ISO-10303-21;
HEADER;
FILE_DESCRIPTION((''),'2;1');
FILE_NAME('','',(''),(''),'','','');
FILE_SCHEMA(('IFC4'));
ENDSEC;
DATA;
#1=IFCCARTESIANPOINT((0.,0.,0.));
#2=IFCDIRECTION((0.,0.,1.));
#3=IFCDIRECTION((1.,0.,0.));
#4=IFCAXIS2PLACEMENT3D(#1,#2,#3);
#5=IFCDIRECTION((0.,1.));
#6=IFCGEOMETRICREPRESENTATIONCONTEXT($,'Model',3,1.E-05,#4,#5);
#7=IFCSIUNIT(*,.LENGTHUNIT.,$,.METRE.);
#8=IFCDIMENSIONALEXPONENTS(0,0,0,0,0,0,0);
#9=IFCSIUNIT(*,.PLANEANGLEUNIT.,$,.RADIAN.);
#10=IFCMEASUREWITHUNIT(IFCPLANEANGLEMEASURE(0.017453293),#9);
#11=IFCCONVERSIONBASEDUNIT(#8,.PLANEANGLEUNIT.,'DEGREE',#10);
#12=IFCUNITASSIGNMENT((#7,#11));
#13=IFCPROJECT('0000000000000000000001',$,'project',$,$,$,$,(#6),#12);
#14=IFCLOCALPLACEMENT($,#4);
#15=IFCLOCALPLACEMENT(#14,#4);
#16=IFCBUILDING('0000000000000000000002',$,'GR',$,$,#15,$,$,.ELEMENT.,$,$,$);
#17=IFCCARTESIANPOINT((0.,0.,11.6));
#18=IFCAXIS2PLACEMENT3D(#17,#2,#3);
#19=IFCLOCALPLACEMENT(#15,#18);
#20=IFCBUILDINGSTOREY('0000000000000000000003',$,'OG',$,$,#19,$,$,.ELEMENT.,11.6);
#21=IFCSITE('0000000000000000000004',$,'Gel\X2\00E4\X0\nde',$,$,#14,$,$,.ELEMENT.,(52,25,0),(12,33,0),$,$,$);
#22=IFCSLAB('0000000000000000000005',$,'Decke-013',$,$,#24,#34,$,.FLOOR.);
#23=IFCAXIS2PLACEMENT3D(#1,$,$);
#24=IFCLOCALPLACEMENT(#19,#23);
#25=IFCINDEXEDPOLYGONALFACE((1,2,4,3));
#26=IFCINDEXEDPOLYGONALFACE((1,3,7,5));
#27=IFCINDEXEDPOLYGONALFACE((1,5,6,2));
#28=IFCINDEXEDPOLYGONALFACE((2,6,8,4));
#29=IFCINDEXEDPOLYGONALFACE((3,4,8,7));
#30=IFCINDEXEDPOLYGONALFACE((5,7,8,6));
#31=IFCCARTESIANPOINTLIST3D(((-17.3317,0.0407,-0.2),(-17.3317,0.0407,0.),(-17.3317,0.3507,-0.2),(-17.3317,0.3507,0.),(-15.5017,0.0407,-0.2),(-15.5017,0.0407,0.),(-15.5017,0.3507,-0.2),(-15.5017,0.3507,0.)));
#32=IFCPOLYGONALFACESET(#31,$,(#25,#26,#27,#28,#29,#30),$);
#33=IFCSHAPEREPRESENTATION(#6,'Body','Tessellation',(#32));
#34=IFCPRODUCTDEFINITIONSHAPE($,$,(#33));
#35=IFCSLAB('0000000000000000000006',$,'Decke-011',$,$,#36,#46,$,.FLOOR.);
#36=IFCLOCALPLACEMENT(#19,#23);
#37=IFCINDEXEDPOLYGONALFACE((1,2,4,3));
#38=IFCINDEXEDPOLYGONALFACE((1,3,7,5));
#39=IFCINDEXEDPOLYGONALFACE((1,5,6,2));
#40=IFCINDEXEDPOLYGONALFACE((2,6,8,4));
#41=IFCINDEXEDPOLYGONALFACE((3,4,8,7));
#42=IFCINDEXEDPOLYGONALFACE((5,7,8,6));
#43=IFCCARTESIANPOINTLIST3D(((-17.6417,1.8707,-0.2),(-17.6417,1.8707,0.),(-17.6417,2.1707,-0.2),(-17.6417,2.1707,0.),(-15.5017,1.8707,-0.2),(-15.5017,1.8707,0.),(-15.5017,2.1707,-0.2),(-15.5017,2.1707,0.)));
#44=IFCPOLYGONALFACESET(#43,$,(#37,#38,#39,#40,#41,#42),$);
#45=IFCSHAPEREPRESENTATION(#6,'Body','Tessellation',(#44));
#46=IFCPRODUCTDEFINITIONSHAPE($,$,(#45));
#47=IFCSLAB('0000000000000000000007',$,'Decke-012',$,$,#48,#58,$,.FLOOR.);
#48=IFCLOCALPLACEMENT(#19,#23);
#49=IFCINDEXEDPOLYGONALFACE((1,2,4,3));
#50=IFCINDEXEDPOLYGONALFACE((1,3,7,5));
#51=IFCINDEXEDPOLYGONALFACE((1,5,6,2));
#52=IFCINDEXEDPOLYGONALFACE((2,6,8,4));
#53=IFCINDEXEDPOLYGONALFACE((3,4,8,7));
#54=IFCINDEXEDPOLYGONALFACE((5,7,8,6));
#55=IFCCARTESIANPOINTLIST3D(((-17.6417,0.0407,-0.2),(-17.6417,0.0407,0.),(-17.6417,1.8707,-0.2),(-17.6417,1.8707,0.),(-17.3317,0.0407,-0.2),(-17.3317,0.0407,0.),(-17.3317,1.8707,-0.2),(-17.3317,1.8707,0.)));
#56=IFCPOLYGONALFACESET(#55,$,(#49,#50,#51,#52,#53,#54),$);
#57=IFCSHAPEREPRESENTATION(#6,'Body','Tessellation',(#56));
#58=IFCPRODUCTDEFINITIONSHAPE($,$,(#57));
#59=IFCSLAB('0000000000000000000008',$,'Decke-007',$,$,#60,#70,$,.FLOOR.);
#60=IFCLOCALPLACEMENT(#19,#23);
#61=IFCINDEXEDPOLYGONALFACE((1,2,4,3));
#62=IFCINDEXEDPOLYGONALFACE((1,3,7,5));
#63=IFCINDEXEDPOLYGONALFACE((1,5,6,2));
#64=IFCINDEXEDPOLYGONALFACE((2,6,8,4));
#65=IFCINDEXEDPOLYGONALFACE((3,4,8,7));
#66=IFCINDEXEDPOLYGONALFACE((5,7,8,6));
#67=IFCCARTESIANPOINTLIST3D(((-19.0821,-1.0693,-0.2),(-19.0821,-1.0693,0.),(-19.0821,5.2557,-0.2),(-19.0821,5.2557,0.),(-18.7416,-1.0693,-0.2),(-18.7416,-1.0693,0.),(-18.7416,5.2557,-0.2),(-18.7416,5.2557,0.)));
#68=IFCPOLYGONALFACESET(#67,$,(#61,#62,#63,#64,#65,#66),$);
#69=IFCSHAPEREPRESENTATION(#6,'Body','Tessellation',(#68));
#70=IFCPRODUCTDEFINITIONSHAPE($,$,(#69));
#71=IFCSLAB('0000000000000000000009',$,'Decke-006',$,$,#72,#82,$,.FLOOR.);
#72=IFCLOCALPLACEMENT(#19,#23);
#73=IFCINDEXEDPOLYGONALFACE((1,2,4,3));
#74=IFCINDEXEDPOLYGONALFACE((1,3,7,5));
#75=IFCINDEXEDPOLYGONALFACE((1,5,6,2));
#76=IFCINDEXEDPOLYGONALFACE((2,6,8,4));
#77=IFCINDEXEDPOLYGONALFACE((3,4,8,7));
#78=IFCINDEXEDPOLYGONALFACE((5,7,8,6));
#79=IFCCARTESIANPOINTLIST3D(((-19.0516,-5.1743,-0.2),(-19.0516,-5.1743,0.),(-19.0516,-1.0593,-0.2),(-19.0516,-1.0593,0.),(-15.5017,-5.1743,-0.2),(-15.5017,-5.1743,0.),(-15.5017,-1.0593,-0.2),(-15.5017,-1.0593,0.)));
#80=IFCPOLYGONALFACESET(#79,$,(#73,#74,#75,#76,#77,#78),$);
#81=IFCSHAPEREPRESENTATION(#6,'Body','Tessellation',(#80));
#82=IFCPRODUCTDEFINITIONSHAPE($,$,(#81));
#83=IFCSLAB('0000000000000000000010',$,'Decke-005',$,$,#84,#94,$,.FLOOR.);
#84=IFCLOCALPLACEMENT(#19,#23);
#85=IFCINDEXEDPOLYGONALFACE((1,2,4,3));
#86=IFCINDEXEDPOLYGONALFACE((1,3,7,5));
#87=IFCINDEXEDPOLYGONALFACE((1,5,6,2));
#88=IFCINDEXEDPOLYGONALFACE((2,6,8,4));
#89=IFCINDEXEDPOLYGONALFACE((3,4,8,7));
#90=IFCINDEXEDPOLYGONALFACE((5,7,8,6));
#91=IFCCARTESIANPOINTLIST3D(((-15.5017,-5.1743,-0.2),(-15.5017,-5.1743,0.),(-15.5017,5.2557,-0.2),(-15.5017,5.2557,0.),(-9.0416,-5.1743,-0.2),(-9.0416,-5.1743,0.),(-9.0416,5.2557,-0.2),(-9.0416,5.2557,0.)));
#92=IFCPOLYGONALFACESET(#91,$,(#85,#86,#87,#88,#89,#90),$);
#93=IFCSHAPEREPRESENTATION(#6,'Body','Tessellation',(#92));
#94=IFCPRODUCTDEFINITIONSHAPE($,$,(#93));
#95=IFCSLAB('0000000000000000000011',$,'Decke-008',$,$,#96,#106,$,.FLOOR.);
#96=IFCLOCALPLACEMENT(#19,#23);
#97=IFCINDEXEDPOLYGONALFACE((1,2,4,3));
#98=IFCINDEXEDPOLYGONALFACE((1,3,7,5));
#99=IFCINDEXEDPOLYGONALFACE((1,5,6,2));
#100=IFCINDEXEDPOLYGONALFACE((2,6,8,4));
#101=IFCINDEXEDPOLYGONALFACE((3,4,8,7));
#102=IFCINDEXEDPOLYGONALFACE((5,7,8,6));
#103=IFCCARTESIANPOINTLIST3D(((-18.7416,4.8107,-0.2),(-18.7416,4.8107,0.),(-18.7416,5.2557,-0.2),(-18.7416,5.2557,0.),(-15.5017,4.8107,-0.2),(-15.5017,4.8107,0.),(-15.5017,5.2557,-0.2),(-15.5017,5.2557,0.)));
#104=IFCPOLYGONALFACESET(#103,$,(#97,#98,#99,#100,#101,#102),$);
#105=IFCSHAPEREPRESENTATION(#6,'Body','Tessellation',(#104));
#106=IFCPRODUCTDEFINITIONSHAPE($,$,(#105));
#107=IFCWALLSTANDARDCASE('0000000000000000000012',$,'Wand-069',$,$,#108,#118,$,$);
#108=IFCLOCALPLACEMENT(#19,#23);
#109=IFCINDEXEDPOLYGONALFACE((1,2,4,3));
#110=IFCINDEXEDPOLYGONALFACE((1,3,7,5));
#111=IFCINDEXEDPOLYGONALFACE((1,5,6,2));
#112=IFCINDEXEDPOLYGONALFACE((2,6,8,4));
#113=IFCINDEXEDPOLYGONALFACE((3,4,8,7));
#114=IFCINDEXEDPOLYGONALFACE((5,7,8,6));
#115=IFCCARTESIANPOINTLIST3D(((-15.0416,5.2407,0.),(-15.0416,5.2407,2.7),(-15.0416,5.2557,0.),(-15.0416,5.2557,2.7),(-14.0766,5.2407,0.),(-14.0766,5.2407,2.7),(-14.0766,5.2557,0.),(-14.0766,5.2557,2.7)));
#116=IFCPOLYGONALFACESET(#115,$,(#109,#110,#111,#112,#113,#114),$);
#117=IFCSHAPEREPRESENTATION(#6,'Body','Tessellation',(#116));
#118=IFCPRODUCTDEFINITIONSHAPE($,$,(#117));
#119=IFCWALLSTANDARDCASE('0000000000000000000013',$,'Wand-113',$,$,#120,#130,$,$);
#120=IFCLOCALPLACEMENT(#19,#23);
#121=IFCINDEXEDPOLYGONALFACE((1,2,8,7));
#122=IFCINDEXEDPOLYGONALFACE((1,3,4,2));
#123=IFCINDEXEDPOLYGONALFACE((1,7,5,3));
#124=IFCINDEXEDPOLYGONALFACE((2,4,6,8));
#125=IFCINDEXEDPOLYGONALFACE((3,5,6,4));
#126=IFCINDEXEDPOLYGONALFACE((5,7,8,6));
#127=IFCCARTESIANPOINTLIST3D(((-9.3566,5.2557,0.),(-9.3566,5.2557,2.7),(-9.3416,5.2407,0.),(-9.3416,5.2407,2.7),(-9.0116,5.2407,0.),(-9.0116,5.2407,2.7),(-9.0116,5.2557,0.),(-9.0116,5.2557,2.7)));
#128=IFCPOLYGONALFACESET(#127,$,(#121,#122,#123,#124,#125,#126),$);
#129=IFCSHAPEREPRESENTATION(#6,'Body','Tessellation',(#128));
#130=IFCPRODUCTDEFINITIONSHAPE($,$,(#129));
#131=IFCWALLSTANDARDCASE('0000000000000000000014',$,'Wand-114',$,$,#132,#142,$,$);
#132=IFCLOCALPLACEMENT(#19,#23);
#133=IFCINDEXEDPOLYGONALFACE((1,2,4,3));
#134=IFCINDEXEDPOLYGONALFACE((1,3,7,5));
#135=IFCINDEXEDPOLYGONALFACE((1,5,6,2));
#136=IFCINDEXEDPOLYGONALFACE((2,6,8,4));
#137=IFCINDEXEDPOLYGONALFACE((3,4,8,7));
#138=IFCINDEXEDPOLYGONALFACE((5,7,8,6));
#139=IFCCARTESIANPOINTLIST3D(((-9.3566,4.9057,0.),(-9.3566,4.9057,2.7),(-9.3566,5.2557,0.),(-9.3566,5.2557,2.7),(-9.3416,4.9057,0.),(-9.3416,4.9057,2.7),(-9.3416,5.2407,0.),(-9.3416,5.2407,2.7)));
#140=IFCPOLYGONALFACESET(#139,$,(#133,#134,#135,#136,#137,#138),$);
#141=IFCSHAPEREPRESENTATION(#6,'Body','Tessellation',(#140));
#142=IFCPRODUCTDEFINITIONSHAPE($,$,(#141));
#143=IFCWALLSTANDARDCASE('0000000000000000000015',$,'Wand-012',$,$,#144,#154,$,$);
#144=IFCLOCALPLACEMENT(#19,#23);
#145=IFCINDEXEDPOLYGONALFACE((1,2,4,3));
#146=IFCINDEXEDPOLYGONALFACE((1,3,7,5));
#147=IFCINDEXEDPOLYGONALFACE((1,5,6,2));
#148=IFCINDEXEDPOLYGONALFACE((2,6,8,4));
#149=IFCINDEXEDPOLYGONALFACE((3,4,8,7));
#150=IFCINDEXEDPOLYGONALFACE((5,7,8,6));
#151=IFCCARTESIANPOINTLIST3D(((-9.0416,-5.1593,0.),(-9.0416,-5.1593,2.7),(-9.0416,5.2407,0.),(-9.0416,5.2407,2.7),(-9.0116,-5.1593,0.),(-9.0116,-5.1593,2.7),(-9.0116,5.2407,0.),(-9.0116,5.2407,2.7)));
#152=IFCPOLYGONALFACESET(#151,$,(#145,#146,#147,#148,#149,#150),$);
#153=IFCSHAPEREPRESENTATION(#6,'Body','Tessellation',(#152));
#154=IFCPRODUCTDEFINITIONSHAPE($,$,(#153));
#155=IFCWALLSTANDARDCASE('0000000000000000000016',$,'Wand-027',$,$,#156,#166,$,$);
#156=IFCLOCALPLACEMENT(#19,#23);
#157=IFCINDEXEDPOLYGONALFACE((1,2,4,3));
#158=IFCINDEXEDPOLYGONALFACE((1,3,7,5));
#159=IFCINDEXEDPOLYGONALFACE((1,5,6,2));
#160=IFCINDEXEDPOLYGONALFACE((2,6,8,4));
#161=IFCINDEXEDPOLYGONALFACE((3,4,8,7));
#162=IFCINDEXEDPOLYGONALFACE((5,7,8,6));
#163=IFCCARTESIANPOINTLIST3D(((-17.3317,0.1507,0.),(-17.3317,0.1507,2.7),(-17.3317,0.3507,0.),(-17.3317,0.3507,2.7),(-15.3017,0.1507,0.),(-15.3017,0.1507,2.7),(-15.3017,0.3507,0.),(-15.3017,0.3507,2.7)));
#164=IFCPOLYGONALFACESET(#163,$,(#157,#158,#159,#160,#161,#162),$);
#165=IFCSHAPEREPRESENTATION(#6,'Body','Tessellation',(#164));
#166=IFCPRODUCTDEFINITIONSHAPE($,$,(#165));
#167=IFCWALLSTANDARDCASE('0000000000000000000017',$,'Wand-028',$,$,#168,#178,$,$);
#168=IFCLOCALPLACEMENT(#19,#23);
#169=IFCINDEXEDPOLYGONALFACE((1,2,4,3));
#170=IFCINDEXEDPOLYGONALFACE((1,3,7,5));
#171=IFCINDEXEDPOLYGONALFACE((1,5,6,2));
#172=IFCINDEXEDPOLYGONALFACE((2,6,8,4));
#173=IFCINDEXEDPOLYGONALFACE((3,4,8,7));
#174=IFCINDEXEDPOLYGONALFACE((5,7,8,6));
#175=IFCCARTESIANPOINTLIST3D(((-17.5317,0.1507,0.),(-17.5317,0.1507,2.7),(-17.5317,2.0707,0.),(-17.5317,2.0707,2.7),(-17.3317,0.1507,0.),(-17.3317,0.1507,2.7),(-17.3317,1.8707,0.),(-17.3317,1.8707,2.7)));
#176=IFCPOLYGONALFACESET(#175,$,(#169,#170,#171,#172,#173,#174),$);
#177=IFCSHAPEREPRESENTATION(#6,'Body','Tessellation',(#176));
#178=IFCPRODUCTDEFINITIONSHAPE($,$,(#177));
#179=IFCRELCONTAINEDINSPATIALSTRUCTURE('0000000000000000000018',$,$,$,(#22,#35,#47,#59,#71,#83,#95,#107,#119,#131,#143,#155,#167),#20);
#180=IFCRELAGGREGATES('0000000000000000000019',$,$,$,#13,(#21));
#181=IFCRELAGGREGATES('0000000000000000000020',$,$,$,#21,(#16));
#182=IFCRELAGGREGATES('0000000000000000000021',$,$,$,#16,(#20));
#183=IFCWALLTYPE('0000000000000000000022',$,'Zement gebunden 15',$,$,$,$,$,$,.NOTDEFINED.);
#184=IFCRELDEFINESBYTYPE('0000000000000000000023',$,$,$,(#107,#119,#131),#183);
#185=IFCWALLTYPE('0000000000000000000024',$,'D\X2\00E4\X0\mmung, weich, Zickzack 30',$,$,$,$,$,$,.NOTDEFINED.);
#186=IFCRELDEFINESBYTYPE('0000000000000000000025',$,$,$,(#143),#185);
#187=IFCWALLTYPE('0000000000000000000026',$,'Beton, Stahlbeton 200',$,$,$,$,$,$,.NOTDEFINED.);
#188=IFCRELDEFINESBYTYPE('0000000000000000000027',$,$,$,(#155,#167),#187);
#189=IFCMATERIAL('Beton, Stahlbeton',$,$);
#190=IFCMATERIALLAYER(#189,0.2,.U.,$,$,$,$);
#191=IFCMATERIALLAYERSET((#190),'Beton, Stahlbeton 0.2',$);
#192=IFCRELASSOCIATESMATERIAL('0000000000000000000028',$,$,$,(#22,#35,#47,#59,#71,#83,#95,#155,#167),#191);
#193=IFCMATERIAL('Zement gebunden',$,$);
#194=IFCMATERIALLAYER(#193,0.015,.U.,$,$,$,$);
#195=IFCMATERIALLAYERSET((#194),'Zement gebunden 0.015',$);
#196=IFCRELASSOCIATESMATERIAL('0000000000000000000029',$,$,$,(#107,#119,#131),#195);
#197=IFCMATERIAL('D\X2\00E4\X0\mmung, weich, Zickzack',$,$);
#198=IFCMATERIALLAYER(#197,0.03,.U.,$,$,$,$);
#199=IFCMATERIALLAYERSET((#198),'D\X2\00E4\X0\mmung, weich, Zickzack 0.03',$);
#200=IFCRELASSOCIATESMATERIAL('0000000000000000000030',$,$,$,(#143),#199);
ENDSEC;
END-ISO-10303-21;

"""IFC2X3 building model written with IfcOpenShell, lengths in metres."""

from ifc_helpers import new_model, entity, si_unit, converted_unit, direction, frame, origin_with_axes, place, context, project, spatial, polyline, outline, extrude, material, layer, layer_set, layer_usage, type_object, element, save


model = new_model("IFC2X3")

# Units and contexts
model_context = context("Model", 3, precision=1e-05, world=origin_with_axes(), true_north=direction((0.0, 1.0)))
ifc_project = project(units=[si_unit("LENGTHUNIT", "METRE"), converted_unit("PLANEANGLEUNIT", "DEGREE", entity("IfcPlaneAngleMeasure", 0.017453293), si_unit("PLANEANGLEUNIT", "RADIAN"), dimensions=[0, 0, 0, 0, 0, 0, 0])], contexts=[model_context])

# Site, building, storey
site_placement = place(None, origin_with_axes())
site = spatial("IfcSite", under=ifc_project, at=site_placement, Name="Gelände", CompositionType="ELEMENT", RefLatitude=(52, 25, 0), RefLongitude=(12, 33, 0))
building_placement = place(site_placement, origin_with_axes())
building = spatial("IfcBuilding", under=site, at=building_placement, Name="GR", CompositionType="ELEMENT")
storey_placement = place(building_placement, frame((0.0, 0.0, 11.6), z_axis=(0.0, 0.0, 1.0), x_axis=(1.0, 0.0, 0.0)))
storey = spatial("IfcBuildingStorey", under=building, at=storey_placement, Name="OG", CompositionType="ELEMENT", Elevation=11.6)

# Slabs
ifc_material_1 = material(Name="Beton, Stahlbeton")
ifc_layer_1 = layer(ifc_material_1, 0.2, ventilated="UNKNOWN")
ifc_layer_set_1 = layer_set([ifc_layer_1], Name="Beton, Stahlbeton 0.2")
ifc_layer_usage_1 = layer_usage(ifc_layer_set_1, "AXIS3", "NEGATIVE", 0.2)
slab_1_placement = place(storey_placement, frame((-17.3317, 0.3507, -0.2), z_axis=(0.0, 0.0, 1.0), x_axis=(1.0, 0.0, 0.0)))
element("IfcSlab", 1, at=slab_1_placement, inside=storey, material=ifc_layer_usage_1, Name="Decke-013", PredefinedType="FLOOR", context=model_context, shape_type="SweptSolid", body=[
    extrude(outline(polyline([(0.0, 0.0), (0.0, -0.31), (1.83, -0.31), (1.83, 0.0), (0.0, 0.0)])), origin_with_axes(), (0.0, 0.0, 1.0), 0.2),
])
ifc_layer_usage_2 = layer_usage(ifc_layer_set_1, "AXIS3", "NEGATIVE", 0.2)
slab_2_placement = place(storey_placement, frame((-15.5017, 2.1707, -0.2), z_axis=(0.0, 0.0, 1.0), x_axis=(1.0, 0.0, 0.0)))
element("IfcSlab", 2, at=slab_2_placement, inside=storey, material=ifc_layer_usage_2, Name="Decke-011", PredefinedType="FLOOR", context=model_context, shape_type="SweptSolid", body=[
    extrude(outline(polyline([(0.0, 0.0), (-2.14, 0.0), (-2.14, -0.3), (0.0, -0.3), (0.0, 0.0)])), origin_with_axes(), (0.0, 0.0, 1.0), 0.2),
])
ifc_layer_usage_3 = layer_usage(ifc_layer_set_1, "AXIS3", "NEGATIVE", 0.2)
slab_3_placement = place(storey_placement, frame((-17.3317, 1.8707, -0.2), z_axis=(0.0, 0.0, 1.0), x_axis=(1.0, 0.0, 0.0)))
element("IfcSlab", 3, at=slab_3_placement, inside=storey, material=ifc_layer_usage_3, Name="Decke-012", PredefinedType="FLOOR", context=model_context, shape_type="SweptSolid", body=[
    extrude(outline(polyline([(0.0, 0.0), (-0.31, 0.0), (-0.31, -1.83), (0.0, -1.83), (0.0, 0.0)])), origin_with_axes(), (0.0, 0.0, 1.0), 0.2),
])
ifc_layer_usage_4 = layer_usage(ifc_layer_set_1, "AXIS3", "NEGATIVE", 0.2)
slab_4_placement = place(storey_placement, frame((-19.0821, 5.2557, -0.2), z_axis=(0.0, 0.0, 1.0), x_axis=(1.0, 0.0, 0.0)))
element("IfcSlab", 4, at=slab_4_placement, inside=storey, material=ifc_layer_usage_4, Name="Decke-007", PredefinedType="FLOOR", context=model_context, shape_type="SweptSolid", body=[
    extrude(outline(polyline([(0.0, 0.0), (0.0, -6.325), (0.3405, -6.325), (0.3405, 0.0), (0.0, 0.0)])), origin_with_axes(), (0.0, 0.0, 1.0), 0.2),
])
ifc_layer_usage_5 = layer_usage(ifc_layer_set_1, "AXIS3", "NEGATIVE", 0.2)
slab_5_placement = place(storey_placement, frame((-15.5017, -1.0593, -0.2), z_axis=(0.0, 0.0, 1.0), x_axis=(1.0, 0.0, 0.0)))
element("IfcSlab", 5, at=slab_5_placement, inside=storey, material=ifc_layer_usage_5, Name="Decke-006", PredefinedType="FLOOR", context=model_context, shape_type="SweptSolid", body=[
    extrude(outline(polyline([(0.0, 0.0), (-3.55, 0.0), (-3.55, -4.115), (0.0, -4.115), (0.0, 0.0)])), origin_with_axes(), (0.0, 0.0, 1.0), 0.2),
])
ifc_layer_usage_6 = layer_usage(ifc_layer_set_1, "AXIS3", "NEGATIVE", 0.2)
slab_6_placement = place(storey_placement, frame((-15.5017, 5.2557, -0.2), z_axis=(0.0, 0.0, 1.0), x_axis=(1.0, 0.0, 0.0)))
element("IfcSlab", 6, at=slab_6_placement, inside=storey, material=ifc_layer_usage_6, Name="Decke-005", PredefinedType="FLOOR", context=model_context, shape_type="SweptSolid", body=[
    extrude(outline(polyline([(0.0, 0.0), (0.0, -10.43), (6.46, -10.43), (6.46, 0.0), (0.0, 0.0)])), origin_with_axes(), (0.0, 0.0, 1.0), 0.2),
])
ifc_layer_usage_7 = layer_usage(ifc_layer_set_1, "AXIS3", "NEGATIVE", 0.2)
slab_7_placement = place(storey_placement, frame((-18.7416, 5.2557, -0.2), z_axis=(0.0, 0.0, 1.0), x_axis=(1.0, 0.0, 0.0)))
element("IfcSlab", 7, at=slab_7_placement, inside=storey, material=ifc_layer_usage_7, Name="Decke-008", PredefinedType="FLOOR", context=model_context, shape_type="SweptSolid", body=[
    extrude(outline(polyline([(0.0, 0.0), (0.0, -0.445), (3.24, -0.445), (3.24, 0.0), (0.0, 0.0)])), origin_with_axes(), (0.0, 0.0, 1.0), 0.2),
])

# Walls
ifc_material_2 = material(Name="Zement gebunden")
ifc_layer_2 = layer(ifc_material_2, 0.015, ventilated="UNKNOWN")
ifc_layer_set_2 = layer_set([ifc_layer_2], Name="Zement gebunden 0.015")
ifc_layer_usage_8 = layer_usage(ifc_layer_set_2, "AXIS2", "NEGATIVE", 0.0)
wall_type_1 = type_object("IfcWallType", Name="Zement gebunden 15", PredefinedType="NOTDEFINED")
wall_1_placement = place(storey_placement, frame((-14.0766, 5.2407, 0.0), z_axis=(0.0, 0.0, 1.0), x_axis=(-1.0, 0.0, 0.0)))
element("IfcWallStandardCase", 8, at=wall_1_placement, inside=storey, type_object=wall_type_1, material=ifc_layer_usage_8, Name="Wand-069", context=model_context, shape_type="SweptSolid", body=[
    extrude(outline(polyline([(0.0, -0.015), (0.965, -0.015), (0.965, 0.0), (0.0, 0.0), (0.0, -0.015)])), origin_with_axes(), (0.0, 0.0, 1.0), 2.7),
])
ifc_layer_usage_9 = layer_usage(ifc_layer_set_2, "AXIS2", "NEGATIVE", 0.0)
wall_2_placement = place(storey_placement, frame((-9.0116, 5.2407, 0.0), z_axis=(0.0, 0.0, 1.0), x_axis=(-1.0, 0.0, 0.0)))
element("IfcWallStandardCase", 9, at=wall_2_placement, inside=storey, type_object=wall_type_1, material=ifc_layer_usage_9, Name="Wand-113", context=model_context, shape_type="SweptSolid", body=[
    extrude(outline(polyline([(0.0, -0.015), (0.345, -0.015), (0.33, 0.0), (0.0, 0.0), (0.0, -0.015)])), origin_with_axes(), (0.0, 0.0, 1.0), 2.7),
])
ifc_layer_usage_10 = layer_usage(ifc_layer_set_2, "AXIS2", "NEGATIVE", 0.0)
wall_3_placement = place(storey_placement, frame((-9.3416, 5.2407, 0.0), z_axis=(0.0, 0.0, 1.0), x_axis=(0.0, -1.0, 0.0)))
element("IfcWallStandardCase", 10, at=wall_3_placement, inside=storey, type_object=wall_type_1, material=ifc_layer_usage_10, Name="Wand-114", context=model_context, shape_type="SweptSolid", body=[
    extrude(outline(polyline([(-0.015, -0.015), (0.335, -0.015), (0.335, 0.0), (0.0, 0.0), (-0.015, -0.015)])), origin_with_axes(), (0.0, 0.0, 1.0), 2.7),
])
ifc_material_3 = material(Name="Dämmung, weich, Zickzack")
ifc_layer_3 = layer(ifc_material_3, 0.03, ventilated="UNKNOWN")
ifc_layer_set_3 = layer_set([ifc_layer_3], Name="Dämmung, weich, Zickzack 0.03")
ifc_layer_usage_11 = layer_usage(ifc_layer_set_3, "AXIS2", "POSITIVE", 0.0)
wall_type_2 = type_object("IfcWallType", Name="Dämmung, weich, Zickzack 30", PredefinedType="NOTDEFINED")
wall_4_placement = place(storey_placement, frame((-9.0416, 5.2407, 0.0), z_axis=(0.0, 0.0, 1.0), x_axis=(0.0, -1.0, 0.0)))
element("IfcWallStandardCase", 11, at=wall_4_placement, inside=storey, type_object=wall_type_2, material=ifc_layer_usage_11, Name="Wand-012", context=model_context, shape_type="SweptSolid", body=[
    extrude(outline(polyline([(0.0, 0.0), (10.4, 0.0), (10.4, 0.03), (0.0, 0.03), (0.0, 0.0)])), origin_with_axes(), (0.0, 0.0, 1.0), 2.7),
])
ifc_layer_usage_12 = layer_usage(ifc_layer_set_1, "AXIS2", "NEGATIVE", 0.0)
wall_type_3 = type_object("IfcWallType", Name="Beton, Stahlbeton 200", PredefinedType="NOTDEFINED")
wall_5_placement = place(storey_placement, frame((-15.3017, 0.1507, 0.0), z_axis=(0.0, 0.0, 1.0), x_axis=(-1.0, 0.0, 0.0)))
element("IfcWallStandardCase", 12, at=wall_5_placement, inside=storey, type_object=wall_type_3, material=ifc_layer_usage_12, Name="Wand-027", context=model_context, shape_type="SweptSolid", body=[
    extrude(outline(polyline([(0.0, -0.2), (2.03, -0.2), (2.03, 0.0), (0.0, 0.0), (0.0, -0.2)])), origin_with_axes(), (0.0, 0.0, 1.0), 2.7),
])
ifc_layer_usage_13 = layer_usage(ifc_layer_set_1, "AXIS2", "NEGATIVE", 0.0)
wall_6_placement = place(storey_placement, frame((-17.5317, 0.1507, 0.0), z_axis=(0.0, 0.0, 1.0), x_axis=(0.0, 1.0, 0.0)))
element("IfcWallStandardCase", 13, at=wall_6_placement, inside=storey, type_object=wall_type_3, material=ifc_layer_usage_13, Name="Wand-028", context=model_context, shape_type="SweptSolid", body=[
    extrude(outline(polyline([(0.0, -0.2), (1.72, -0.2), (1.92, 0.0), (0.0, 0.0), (0.0, -0.2)])), origin_with_axes(), (0.0, 0.0, 1.0), 2.7),
])

save(model, "model.ifc")
